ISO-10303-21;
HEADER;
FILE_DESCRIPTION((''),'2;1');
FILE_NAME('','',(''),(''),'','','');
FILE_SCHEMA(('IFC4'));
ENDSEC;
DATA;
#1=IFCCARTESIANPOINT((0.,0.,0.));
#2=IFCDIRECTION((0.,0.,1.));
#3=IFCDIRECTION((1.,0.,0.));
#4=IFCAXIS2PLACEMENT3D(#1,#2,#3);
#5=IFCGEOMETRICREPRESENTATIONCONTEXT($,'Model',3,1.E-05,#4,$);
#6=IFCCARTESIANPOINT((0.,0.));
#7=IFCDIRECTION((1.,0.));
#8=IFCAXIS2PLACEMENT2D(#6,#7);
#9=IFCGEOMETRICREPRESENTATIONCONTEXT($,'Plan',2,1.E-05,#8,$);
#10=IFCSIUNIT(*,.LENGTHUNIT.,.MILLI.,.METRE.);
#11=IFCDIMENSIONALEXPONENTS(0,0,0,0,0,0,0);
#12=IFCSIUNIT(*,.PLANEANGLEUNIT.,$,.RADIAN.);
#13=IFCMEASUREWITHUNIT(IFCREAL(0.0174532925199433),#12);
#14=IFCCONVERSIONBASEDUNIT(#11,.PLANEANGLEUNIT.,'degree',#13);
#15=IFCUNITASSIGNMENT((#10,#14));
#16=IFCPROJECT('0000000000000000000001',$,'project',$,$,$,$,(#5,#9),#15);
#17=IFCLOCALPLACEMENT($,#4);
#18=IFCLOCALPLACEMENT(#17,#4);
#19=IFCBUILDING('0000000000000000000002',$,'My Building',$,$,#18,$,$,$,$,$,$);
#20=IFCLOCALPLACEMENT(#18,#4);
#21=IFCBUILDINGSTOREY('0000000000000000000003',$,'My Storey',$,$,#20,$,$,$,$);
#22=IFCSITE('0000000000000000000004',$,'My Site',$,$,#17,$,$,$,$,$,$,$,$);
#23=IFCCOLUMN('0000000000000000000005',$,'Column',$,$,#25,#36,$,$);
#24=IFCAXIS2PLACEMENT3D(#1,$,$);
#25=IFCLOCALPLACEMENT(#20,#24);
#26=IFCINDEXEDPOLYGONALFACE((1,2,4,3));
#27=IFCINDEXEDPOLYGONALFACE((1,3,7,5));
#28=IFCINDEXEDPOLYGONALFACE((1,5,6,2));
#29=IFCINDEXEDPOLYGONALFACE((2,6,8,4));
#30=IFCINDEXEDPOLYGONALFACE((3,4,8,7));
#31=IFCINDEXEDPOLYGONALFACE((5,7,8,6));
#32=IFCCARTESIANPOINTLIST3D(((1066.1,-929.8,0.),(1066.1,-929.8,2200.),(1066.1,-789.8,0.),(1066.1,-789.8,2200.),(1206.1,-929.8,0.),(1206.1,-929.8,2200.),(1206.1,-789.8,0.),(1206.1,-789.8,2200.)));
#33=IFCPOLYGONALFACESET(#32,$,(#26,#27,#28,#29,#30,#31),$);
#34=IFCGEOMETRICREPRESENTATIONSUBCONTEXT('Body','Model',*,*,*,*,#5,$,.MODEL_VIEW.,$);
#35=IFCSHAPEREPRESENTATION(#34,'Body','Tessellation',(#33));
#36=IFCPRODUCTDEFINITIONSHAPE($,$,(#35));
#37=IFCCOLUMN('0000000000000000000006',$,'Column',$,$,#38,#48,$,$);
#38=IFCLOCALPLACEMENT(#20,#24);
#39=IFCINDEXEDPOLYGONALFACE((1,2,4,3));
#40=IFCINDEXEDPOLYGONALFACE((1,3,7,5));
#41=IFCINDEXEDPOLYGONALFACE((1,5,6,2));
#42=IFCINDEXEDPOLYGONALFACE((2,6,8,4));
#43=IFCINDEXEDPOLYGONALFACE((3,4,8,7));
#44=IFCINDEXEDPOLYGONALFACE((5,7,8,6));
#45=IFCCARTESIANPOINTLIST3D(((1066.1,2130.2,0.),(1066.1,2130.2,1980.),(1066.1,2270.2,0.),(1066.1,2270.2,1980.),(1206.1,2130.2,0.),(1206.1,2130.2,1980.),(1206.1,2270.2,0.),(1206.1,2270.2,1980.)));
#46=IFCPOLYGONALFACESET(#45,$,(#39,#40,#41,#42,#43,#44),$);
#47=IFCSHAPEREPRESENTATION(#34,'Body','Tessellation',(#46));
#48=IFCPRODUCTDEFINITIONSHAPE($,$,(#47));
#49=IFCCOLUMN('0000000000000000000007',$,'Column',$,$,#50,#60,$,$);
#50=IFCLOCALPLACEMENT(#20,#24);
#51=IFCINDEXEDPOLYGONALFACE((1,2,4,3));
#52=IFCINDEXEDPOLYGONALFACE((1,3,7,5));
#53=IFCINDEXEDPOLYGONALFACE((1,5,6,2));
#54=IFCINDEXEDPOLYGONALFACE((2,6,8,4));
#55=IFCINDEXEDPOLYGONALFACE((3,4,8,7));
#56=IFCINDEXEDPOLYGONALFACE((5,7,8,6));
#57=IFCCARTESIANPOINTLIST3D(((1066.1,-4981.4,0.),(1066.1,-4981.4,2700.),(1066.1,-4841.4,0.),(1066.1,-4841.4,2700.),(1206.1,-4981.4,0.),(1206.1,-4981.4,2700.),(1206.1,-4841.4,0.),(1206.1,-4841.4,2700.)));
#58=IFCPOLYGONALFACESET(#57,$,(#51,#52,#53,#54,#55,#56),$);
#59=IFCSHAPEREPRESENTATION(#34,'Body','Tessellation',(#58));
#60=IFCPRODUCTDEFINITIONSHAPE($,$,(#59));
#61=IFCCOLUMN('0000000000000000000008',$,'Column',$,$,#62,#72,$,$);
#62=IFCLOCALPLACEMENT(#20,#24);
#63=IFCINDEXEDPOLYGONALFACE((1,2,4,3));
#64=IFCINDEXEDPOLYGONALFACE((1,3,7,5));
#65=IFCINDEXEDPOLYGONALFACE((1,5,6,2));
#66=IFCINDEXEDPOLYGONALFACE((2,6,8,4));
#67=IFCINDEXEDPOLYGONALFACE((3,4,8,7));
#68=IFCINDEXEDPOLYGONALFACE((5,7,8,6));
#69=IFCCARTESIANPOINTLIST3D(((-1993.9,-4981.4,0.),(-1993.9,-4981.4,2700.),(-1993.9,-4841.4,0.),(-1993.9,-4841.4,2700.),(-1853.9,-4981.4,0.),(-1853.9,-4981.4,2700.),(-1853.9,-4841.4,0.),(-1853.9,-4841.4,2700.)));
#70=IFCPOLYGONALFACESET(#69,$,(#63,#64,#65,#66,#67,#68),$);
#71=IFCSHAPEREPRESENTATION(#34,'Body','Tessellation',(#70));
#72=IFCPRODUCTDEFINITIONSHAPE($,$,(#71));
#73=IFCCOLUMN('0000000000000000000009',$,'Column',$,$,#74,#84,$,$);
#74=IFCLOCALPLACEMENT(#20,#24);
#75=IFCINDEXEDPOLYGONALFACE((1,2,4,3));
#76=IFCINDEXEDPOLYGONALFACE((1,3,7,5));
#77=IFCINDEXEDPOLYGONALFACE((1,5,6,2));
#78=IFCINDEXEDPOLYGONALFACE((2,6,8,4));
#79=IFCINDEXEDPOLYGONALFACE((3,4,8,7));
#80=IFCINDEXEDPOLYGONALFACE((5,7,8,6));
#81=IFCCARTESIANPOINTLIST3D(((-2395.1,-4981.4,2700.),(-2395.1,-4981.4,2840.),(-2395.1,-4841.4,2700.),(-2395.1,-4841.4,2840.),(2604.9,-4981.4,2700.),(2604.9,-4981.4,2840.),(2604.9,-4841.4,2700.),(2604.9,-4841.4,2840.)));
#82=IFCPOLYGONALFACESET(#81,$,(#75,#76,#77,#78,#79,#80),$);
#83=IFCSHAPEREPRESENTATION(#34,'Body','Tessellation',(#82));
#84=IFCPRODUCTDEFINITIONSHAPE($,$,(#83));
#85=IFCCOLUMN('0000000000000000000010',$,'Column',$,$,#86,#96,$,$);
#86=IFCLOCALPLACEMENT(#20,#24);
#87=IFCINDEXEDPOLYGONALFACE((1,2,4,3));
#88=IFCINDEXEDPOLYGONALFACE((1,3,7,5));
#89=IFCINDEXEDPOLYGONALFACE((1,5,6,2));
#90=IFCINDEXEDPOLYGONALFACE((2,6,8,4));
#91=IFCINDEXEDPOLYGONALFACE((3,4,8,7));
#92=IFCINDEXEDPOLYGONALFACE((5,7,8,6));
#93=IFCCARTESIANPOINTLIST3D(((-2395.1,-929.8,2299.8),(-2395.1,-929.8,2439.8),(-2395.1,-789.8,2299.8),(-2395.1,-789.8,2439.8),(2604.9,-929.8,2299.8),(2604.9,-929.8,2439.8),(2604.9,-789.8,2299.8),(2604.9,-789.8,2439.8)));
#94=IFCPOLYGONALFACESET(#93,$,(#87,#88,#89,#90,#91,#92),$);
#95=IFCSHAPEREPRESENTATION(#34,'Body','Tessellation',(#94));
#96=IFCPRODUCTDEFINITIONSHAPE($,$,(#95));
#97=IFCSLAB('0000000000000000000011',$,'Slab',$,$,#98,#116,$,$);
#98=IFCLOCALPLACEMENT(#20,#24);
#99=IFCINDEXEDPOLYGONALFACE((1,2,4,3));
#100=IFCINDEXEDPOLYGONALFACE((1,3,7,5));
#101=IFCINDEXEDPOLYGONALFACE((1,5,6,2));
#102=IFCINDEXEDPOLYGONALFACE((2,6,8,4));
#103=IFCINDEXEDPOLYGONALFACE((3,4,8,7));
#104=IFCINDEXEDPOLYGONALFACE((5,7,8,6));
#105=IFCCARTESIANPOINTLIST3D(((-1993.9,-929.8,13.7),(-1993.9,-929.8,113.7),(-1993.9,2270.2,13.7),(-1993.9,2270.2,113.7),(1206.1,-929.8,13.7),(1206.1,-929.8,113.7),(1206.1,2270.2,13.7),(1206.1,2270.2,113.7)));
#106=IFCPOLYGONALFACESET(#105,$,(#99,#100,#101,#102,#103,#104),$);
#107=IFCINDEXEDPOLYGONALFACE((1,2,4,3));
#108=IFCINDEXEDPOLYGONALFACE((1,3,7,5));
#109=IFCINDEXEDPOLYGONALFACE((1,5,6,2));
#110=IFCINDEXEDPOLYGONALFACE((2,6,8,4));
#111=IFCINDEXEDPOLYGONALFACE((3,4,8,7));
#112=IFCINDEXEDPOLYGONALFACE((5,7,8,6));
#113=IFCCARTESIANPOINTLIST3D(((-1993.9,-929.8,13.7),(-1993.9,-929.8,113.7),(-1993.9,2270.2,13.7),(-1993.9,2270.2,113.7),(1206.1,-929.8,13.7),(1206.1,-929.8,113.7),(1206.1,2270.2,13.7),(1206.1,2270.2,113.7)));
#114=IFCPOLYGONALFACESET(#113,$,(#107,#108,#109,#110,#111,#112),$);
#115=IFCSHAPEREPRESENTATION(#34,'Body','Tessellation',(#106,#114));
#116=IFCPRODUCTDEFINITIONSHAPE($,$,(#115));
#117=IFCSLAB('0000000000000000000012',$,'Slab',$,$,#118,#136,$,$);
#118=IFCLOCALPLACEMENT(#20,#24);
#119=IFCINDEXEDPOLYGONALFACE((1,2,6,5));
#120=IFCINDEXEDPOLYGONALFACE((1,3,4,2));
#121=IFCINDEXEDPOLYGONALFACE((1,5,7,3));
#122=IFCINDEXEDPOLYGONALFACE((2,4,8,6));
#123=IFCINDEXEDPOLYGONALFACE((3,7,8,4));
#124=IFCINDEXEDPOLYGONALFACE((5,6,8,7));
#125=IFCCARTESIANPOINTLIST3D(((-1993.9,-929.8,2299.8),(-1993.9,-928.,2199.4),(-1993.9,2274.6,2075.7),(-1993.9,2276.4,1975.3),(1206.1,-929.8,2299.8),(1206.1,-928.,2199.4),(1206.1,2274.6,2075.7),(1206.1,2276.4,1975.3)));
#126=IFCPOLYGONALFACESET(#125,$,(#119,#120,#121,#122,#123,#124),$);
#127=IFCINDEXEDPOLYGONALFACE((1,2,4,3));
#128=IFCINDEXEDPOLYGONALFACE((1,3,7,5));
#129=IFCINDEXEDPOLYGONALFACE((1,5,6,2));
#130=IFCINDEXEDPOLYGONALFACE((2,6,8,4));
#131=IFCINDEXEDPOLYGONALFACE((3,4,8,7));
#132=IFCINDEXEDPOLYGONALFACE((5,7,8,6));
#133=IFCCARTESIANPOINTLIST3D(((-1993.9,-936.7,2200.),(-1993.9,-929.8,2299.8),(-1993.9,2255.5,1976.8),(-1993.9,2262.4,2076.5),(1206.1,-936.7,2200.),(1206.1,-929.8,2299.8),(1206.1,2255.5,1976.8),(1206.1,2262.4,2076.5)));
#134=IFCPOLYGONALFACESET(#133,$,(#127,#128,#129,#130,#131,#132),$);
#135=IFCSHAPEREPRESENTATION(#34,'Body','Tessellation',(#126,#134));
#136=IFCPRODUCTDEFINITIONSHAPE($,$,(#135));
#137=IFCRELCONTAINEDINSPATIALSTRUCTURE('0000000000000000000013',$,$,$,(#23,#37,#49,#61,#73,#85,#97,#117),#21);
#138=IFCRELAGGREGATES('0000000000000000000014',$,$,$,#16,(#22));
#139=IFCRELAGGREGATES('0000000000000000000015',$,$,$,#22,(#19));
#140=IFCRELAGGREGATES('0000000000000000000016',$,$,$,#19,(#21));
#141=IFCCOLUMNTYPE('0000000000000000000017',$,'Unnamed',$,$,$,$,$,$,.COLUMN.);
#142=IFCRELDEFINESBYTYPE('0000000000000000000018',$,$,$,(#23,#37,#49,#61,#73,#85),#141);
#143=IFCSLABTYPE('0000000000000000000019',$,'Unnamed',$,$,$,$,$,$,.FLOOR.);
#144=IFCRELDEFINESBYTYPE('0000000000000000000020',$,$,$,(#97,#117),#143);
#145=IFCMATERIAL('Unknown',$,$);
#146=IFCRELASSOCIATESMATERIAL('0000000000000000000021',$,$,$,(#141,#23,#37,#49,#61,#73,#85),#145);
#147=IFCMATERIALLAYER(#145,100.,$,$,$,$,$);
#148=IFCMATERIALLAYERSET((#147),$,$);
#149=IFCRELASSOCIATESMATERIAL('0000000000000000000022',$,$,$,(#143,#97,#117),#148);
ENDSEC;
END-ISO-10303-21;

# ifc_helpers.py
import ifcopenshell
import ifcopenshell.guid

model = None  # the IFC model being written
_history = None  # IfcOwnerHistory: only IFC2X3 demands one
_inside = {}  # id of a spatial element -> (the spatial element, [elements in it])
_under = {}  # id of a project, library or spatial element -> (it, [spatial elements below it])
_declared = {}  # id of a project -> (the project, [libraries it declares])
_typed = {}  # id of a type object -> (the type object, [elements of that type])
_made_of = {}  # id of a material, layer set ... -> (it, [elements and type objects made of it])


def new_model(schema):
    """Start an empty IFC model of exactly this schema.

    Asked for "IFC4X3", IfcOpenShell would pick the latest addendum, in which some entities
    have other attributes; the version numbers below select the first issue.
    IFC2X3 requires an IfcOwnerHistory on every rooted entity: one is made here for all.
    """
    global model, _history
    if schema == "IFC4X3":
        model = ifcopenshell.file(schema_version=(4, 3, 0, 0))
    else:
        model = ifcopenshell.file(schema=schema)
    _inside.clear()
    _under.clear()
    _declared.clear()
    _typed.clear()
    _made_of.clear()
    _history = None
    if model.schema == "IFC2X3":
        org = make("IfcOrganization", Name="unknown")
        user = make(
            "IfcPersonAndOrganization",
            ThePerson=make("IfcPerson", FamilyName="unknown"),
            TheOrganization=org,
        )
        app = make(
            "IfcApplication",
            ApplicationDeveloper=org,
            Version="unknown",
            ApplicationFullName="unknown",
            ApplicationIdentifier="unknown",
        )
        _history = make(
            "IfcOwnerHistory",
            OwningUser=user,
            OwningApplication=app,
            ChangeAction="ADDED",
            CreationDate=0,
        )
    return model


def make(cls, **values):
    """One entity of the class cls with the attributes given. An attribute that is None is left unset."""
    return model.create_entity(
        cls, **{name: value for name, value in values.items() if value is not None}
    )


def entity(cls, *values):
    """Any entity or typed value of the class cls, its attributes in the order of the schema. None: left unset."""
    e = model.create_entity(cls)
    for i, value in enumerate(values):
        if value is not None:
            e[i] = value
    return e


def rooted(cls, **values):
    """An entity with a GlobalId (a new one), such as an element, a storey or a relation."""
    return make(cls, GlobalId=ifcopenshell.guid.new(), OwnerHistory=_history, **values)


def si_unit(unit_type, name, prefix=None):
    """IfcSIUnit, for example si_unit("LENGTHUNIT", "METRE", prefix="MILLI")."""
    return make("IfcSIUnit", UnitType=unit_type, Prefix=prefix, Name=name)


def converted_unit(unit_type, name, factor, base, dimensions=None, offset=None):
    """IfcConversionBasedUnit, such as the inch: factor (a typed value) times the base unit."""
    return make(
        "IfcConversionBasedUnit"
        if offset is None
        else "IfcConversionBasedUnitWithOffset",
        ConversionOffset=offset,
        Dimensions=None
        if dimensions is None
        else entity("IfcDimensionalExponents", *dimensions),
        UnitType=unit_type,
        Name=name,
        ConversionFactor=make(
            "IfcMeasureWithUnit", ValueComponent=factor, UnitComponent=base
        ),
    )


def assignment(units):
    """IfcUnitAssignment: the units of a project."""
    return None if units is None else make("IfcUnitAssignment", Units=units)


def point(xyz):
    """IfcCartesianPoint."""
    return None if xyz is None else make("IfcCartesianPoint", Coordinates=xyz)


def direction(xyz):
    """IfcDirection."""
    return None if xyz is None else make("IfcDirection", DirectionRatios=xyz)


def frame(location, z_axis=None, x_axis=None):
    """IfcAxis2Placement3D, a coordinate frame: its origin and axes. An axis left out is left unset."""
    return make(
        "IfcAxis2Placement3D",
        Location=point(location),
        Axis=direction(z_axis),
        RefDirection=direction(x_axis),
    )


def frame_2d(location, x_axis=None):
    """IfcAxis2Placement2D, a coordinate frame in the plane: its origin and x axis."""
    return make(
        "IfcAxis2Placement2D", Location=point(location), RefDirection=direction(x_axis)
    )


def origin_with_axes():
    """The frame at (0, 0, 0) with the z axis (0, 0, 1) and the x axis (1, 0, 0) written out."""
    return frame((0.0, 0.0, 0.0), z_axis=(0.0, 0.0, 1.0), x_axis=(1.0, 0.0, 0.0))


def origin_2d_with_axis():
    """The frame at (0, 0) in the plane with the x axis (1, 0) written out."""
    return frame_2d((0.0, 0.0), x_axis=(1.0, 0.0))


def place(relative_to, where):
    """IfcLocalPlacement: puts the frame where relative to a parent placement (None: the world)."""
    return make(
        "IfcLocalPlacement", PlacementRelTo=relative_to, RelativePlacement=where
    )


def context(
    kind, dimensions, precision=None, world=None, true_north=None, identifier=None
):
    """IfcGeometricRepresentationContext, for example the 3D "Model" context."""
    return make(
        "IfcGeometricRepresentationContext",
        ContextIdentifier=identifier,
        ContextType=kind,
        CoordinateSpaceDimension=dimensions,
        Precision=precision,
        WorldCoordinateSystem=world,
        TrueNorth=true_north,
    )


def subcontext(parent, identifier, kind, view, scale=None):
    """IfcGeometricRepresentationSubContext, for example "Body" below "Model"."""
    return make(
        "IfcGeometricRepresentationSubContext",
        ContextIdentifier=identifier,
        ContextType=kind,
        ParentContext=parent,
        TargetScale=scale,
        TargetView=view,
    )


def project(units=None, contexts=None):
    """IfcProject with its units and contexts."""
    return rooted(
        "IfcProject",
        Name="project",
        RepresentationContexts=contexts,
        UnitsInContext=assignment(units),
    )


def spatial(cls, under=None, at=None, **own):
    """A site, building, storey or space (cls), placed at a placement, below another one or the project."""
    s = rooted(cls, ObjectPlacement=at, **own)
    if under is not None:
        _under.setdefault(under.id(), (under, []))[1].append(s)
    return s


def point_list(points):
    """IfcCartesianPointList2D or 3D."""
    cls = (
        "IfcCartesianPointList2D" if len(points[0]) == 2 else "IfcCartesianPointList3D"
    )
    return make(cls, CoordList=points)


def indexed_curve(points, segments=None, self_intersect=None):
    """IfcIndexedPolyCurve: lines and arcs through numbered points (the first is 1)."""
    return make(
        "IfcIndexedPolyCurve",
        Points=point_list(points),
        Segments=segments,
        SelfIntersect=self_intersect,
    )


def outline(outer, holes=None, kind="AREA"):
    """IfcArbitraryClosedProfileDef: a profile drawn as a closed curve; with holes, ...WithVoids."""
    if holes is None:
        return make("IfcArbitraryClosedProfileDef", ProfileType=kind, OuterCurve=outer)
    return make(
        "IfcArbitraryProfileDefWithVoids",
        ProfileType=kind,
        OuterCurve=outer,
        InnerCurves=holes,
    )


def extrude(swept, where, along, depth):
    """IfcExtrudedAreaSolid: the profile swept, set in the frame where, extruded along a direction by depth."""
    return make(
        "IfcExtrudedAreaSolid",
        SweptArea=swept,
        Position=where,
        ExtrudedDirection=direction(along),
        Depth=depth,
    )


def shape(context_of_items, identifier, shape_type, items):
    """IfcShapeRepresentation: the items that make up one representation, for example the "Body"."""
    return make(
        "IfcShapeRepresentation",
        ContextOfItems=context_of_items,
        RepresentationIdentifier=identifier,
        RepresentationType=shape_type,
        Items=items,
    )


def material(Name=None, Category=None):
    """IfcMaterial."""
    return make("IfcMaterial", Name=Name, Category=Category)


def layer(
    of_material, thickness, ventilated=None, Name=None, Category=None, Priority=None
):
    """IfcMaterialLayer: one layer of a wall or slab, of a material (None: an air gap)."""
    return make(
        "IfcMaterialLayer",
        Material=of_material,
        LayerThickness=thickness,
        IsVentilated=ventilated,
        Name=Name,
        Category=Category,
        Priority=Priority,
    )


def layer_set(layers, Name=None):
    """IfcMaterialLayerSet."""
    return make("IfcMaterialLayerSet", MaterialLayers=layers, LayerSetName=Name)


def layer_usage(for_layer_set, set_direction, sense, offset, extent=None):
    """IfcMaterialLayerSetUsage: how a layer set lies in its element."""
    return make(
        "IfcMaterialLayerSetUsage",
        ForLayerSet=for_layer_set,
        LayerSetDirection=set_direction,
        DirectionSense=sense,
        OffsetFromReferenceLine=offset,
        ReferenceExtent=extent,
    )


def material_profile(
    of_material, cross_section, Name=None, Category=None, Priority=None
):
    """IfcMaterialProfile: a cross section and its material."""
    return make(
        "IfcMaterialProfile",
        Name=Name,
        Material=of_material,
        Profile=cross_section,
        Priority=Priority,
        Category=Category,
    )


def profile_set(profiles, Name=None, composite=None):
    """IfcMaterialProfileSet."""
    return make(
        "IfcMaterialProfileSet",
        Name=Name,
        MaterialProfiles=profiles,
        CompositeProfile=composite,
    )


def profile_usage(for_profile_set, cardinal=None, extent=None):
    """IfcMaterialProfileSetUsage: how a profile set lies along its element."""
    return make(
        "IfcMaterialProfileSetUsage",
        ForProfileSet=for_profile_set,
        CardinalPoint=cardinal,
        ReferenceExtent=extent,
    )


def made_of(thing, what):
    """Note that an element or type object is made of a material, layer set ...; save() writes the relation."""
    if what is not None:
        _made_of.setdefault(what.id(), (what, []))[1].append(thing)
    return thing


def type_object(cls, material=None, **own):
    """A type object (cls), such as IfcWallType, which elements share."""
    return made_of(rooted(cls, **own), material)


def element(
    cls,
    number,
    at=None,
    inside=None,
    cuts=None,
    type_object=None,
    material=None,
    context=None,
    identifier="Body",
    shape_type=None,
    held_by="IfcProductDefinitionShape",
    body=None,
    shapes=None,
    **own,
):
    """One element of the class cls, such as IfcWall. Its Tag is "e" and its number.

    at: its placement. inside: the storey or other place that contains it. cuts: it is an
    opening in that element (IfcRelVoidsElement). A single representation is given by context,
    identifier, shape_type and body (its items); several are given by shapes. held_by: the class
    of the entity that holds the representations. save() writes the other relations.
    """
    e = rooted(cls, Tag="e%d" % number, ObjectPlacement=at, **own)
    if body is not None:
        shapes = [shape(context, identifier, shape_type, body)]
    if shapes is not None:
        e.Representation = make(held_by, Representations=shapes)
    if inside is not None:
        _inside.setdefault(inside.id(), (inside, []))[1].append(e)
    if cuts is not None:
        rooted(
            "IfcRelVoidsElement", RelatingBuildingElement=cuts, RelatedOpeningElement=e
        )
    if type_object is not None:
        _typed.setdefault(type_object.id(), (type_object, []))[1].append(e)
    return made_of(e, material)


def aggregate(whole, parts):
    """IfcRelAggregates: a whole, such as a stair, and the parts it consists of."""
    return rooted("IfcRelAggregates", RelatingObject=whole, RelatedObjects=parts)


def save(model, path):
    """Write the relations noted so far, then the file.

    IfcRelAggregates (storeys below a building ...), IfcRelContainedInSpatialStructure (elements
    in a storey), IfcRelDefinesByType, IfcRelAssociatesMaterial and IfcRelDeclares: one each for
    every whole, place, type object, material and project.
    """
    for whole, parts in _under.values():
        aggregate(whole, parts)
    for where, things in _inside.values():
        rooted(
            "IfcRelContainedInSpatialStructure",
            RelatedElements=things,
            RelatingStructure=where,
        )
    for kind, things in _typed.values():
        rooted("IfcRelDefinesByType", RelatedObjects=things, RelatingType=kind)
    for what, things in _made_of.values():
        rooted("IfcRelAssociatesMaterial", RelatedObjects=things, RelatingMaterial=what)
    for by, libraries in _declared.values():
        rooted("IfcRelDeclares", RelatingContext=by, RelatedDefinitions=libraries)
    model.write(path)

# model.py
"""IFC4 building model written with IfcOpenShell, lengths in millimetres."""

from ifc_helpers import new_model, entity, si_unit, converted_unit, frame, origin_with_axes, origin_2d_with_axis, place, context, subcontext, project, spatial, indexed_curve, outline, extrude, material, layer, layer_set, layer_usage, material_profile, profile_set, profile_usage, type_object, element, save


model = new_model("IFC4")

# Units and contexts
model_context = context("Model", 3, precision=1e-05, world=origin_with_axes())
plan_context = context("Plan", 2, precision=1e-05, world=origin_2d_with_axis())
body_context = subcontext(model_context, "Body", "Model", "MODEL_VIEW")
ifc_project = project(units=[si_unit("LENGTHUNIT", "METRE", prefix="MILLI"), converted_unit("PLANEANGLEUNIT", "degree", entity("IfcReal", 0.0174532925199433), si_unit("PLANEANGLEUNIT", "RADIAN"), dimensions=[0, 0, 0, 0, 0, 0, 0])], contexts=[model_context, plan_context])

# Site, building, storey
site_placement = place(None, origin_with_axes())
site = spatial("IfcSite", under=ifc_project, at=site_placement, Name="My Site")
building_placement = place(site_placement, origin_with_axes())
building = spatial("IfcBuilding", under=site, at=building_placement, Name="My Building")
storey_placement = place(building_placement, origin_with_axes())
storey = spatial("IfcBuildingStorey", under=building, at=storey_placement, Name="My Storey")

# Columns
ifc_material = material(Name="Unknown")
ifc_material_profile = material_profile(ifc_material, outline(indexed_curve([(0.0, 0.0), (140.0, 0.0), (140.0, 140.0), (0.0, 140.0), (0.0, 0.0)])))
ifc_profile_set = profile_set([ifc_material_profile])
ifc_profile_usage_1 = profile_usage(ifc_profile_set, cardinal=5)
column_type = type_object("IfcColumnType", Name="Unnamed", PredefinedType="COLUMN", material=ifc_profile_set)
column_1_placement = place(storey_placement, frame((1066.1, -929.8, 0.0), z_axis=(0.0, 0.0, 1.0), x_axis=(1.0, 0.0, 0.0)))
element("IfcColumn", 1, at=column_1_placement, inside=storey, type_object=column_type, material=ifc_profile_usage_1, Name="Column", context=body_context, shape_type="SweptSolid", body=[
    extrude(outline(indexed_curve([(0.0, 0.0), (140.0, 0.0), (140.0, 140.0), (0.0, 140.0), (0.0, 0.0)])), origin_with_axes(), (0.0, 0.0, 1.0), 2200.0),
])
ifc_profile_usage_2 = profile_usage(ifc_profile_set, cardinal=5)
column_2_placement = place(storey_placement, frame((1066.1, 2130.2, 0.0), z_axis=(0.0, 0.0, 1.0), x_axis=(1.0, 0.0, 0.0)))
element("IfcColumn", 2, at=column_2_placement, inside=storey, type_object=column_type, material=ifc_profile_usage_2, Name="Column", context=body_context, shape_type="SweptSolid", body=[
    extrude(outline(indexed_curve([(0.0, 0.0), (140.0, 0.0), (140.0, 140.0), (0.0, 140.0), (0.0, 0.0)])), origin_with_axes(), (0.0, 0.0, 1.0), 1980.0),
])
ifc_profile_usage_3 = profile_usage(ifc_profile_set, cardinal=5)
column_3_placement = place(storey_placement, frame((1066.1, -4981.4, 0.0), z_axis=(0.0, 0.0, 1.0), x_axis=(1.0, 0.0, 0.0)))
element("IfcColumn", 3, at=column_3_placement, inside=storey, type_object=column_type, material=ifc_profile_usage_3, Name="Column", context=body_context, shape_type="SweptSolid", body=[
    extrude(outline(indexed_curve([(0.0, 0.0), (140.0, 0.0), (140.0, 140.0), (0.0, 140.0), (0.0, 0.0)])), origin_with_axes(), (0.0, 0.0, 1.0), 2700.0),
])
ifc_profile_usage_4 = profile_usage(ifc_profile_set, cardinal=5)
column_4_placement = place(storey_placement, frame((-1993.9, -4981.4, 0.0), z_axis=(0.0, 0.0, 1.0), x_axis=(1.0, 0.0, 0.0)))
element("IfcColumn", 4, at=column_4_placement, inside=storey, type_object=column_type, material=ifc_profile_usage_4, Name="Column", context=body_context, shape_type="SweptSolid", body=[
    extrude(outline(indexed_curve([(0.0, 0.0), (140.0, 0.0), (140.0, 140.0), (0.0, 140.0), (0.0, 0.0)])), origin_with_axes(), (0.0, 0.0, 1.0), 2700.0),
])
ifc_profile_usage_5 = profile_usage(ifc_profile_set, cardinal=5)
column_5_placement = place(storey_placement, frame((-2395.1, -4981.4, 2840.0), z_axis=(1.0, 0.0, 0.0), x_axis=(0.0, 0.0, -1.0)))
element("IfcColumn", 5, at=column_5_placement, inside=storey, type_object=column_type, material=ifc_profile_usage_5, Name="Column", context=body_context, shape_type="SweptSolid", body=[
    extrude(outline(indexed_curve([(0.0, 0.0), (140.0, 0.0), (140.0, 140.0), (0.0, 140.0), (0.0, 0.0)])), origin_with_axes(), (0.0, 0.0, 1.0), 5000.0),
])
ifc_profile_usage_6 = profile_usage(ifc_profile_set, cardinal=5)
column_6_placement = place(storey_placement, frame((-2395.1, -929.8, 2439.8), z_axis=(1.0, 0.0, 0.0), x_axis=(0.0, 0.0, -1.0)))
element("IfcColumn", 6, at=column_6_placement, inside=storey, type_object=column_type, material=ifc_profile_usage_6, Name="Column", context=body_context, shape_type="SweptSolid", body=[
    extrude(outline(indexed_curve([(0.0, 0.0), (140.0, 0.0), (140.0, 140.0), (0.0, 140.0), (0.0, 0.0)])), origin_with_axes(), (0.0, 0.0, 1.0), 5000.0),
])

# Slabs
ifc_layer = layer(ifc_material, 100.0)
ifc_layer_set = layer_set([ifc_layer])
ifc_layer_usage_1 = layer_usage(ifc_layer_set, "AXIS3", "POSITIVE", -100.0)
slab_type = type_object("IfcSlabType", Name="Unnamed", PredefinedType="FLOOR", material=ifc_layer_set)
slab_1_placement = place(storey_placement, frame((-1993.9, -929.8, 113.7), z_axis=(0.0, 0.0, 1.0), x_axis=(1.0, 0.0, 0.0)))
element("IfcSlab", 7, at=slab_1_placement, inside=storey, type_object=slab_type, material=ifc_layer_usage_1, Name="Slab", context=body_context, shape_type="SweptSolid", body=[
    extrude(outline(indexed_curve([(3200.0, 3200.0), (3200.0, 0.0), (0.0, 0.0), (0.0, 3200.0), (3200.0, 3200.0)])), frame((0.0, 0.0, -100.0), z_axis=(0.0, 0.0, 1.0), x_axis=(1.0, 0.0, 0.0)), (0.0, 0.0, 1.0), 100.0),
    extrude(outline(indexed_curve([(0.0, 3200.0), (0.0, 0.0), (3200.0, 0.0), (3200.0, 3200.0), (0.0, 3200.0)])), frame((0.0, 0.0, -100.0), z_axis=(0.0, 0.0, 1.0), x_axis=(1.0, 0.0, 0.0)), (0.0, 0.0, 1.0), 100.0),
])
ifc_layer_usage_2 = layer_usage(ifc_layer_set, "AXIS3", "POSITIVE", -100.0)
slab_2_placement = place(storey_placement, frame((-1993.9, -929.8, 2299.8), z_axis=(0.0, 0.069756, 0.997564), x_axis=(1.0, 0.0, 0.0)))
element("IfcSlab", 8, at=slab_2_placement, inside=storey, type_object=slab_type, material=ifc_layer_usage_2, Name="Slab", context=body_context, shape_type="SweptSolid", body=[
    extrude(outline(indexed_curve([(0.0, 3212.2), (0.0, 0.0), (3200.0, 0.0), (3200.0, 3212.2), (0.0, 3212.2)])), frame((0.0, 8.7, -100.0), z_axis=(0.0, 0.0, 1.0), x_axis=(1.0, 0.0, 0.0)), (0.0, -0.087156, 0.996195), 100.4),
    extrude(outline(indexed_curve([(3200.0, 3200.0), (3200.0, 0.0), (0.0, 0.0), (0.0, 3200.0), (3200.0, 3200.0)])), frame((0.0, 0.0, -100.0), z_axis=(0.0, 0.0, 1.0), x_axis=(1.0, 0.0, 0.0)), (0.0, 0.0, 1.0), 100.0),
])

save(model, "model.ifc")
